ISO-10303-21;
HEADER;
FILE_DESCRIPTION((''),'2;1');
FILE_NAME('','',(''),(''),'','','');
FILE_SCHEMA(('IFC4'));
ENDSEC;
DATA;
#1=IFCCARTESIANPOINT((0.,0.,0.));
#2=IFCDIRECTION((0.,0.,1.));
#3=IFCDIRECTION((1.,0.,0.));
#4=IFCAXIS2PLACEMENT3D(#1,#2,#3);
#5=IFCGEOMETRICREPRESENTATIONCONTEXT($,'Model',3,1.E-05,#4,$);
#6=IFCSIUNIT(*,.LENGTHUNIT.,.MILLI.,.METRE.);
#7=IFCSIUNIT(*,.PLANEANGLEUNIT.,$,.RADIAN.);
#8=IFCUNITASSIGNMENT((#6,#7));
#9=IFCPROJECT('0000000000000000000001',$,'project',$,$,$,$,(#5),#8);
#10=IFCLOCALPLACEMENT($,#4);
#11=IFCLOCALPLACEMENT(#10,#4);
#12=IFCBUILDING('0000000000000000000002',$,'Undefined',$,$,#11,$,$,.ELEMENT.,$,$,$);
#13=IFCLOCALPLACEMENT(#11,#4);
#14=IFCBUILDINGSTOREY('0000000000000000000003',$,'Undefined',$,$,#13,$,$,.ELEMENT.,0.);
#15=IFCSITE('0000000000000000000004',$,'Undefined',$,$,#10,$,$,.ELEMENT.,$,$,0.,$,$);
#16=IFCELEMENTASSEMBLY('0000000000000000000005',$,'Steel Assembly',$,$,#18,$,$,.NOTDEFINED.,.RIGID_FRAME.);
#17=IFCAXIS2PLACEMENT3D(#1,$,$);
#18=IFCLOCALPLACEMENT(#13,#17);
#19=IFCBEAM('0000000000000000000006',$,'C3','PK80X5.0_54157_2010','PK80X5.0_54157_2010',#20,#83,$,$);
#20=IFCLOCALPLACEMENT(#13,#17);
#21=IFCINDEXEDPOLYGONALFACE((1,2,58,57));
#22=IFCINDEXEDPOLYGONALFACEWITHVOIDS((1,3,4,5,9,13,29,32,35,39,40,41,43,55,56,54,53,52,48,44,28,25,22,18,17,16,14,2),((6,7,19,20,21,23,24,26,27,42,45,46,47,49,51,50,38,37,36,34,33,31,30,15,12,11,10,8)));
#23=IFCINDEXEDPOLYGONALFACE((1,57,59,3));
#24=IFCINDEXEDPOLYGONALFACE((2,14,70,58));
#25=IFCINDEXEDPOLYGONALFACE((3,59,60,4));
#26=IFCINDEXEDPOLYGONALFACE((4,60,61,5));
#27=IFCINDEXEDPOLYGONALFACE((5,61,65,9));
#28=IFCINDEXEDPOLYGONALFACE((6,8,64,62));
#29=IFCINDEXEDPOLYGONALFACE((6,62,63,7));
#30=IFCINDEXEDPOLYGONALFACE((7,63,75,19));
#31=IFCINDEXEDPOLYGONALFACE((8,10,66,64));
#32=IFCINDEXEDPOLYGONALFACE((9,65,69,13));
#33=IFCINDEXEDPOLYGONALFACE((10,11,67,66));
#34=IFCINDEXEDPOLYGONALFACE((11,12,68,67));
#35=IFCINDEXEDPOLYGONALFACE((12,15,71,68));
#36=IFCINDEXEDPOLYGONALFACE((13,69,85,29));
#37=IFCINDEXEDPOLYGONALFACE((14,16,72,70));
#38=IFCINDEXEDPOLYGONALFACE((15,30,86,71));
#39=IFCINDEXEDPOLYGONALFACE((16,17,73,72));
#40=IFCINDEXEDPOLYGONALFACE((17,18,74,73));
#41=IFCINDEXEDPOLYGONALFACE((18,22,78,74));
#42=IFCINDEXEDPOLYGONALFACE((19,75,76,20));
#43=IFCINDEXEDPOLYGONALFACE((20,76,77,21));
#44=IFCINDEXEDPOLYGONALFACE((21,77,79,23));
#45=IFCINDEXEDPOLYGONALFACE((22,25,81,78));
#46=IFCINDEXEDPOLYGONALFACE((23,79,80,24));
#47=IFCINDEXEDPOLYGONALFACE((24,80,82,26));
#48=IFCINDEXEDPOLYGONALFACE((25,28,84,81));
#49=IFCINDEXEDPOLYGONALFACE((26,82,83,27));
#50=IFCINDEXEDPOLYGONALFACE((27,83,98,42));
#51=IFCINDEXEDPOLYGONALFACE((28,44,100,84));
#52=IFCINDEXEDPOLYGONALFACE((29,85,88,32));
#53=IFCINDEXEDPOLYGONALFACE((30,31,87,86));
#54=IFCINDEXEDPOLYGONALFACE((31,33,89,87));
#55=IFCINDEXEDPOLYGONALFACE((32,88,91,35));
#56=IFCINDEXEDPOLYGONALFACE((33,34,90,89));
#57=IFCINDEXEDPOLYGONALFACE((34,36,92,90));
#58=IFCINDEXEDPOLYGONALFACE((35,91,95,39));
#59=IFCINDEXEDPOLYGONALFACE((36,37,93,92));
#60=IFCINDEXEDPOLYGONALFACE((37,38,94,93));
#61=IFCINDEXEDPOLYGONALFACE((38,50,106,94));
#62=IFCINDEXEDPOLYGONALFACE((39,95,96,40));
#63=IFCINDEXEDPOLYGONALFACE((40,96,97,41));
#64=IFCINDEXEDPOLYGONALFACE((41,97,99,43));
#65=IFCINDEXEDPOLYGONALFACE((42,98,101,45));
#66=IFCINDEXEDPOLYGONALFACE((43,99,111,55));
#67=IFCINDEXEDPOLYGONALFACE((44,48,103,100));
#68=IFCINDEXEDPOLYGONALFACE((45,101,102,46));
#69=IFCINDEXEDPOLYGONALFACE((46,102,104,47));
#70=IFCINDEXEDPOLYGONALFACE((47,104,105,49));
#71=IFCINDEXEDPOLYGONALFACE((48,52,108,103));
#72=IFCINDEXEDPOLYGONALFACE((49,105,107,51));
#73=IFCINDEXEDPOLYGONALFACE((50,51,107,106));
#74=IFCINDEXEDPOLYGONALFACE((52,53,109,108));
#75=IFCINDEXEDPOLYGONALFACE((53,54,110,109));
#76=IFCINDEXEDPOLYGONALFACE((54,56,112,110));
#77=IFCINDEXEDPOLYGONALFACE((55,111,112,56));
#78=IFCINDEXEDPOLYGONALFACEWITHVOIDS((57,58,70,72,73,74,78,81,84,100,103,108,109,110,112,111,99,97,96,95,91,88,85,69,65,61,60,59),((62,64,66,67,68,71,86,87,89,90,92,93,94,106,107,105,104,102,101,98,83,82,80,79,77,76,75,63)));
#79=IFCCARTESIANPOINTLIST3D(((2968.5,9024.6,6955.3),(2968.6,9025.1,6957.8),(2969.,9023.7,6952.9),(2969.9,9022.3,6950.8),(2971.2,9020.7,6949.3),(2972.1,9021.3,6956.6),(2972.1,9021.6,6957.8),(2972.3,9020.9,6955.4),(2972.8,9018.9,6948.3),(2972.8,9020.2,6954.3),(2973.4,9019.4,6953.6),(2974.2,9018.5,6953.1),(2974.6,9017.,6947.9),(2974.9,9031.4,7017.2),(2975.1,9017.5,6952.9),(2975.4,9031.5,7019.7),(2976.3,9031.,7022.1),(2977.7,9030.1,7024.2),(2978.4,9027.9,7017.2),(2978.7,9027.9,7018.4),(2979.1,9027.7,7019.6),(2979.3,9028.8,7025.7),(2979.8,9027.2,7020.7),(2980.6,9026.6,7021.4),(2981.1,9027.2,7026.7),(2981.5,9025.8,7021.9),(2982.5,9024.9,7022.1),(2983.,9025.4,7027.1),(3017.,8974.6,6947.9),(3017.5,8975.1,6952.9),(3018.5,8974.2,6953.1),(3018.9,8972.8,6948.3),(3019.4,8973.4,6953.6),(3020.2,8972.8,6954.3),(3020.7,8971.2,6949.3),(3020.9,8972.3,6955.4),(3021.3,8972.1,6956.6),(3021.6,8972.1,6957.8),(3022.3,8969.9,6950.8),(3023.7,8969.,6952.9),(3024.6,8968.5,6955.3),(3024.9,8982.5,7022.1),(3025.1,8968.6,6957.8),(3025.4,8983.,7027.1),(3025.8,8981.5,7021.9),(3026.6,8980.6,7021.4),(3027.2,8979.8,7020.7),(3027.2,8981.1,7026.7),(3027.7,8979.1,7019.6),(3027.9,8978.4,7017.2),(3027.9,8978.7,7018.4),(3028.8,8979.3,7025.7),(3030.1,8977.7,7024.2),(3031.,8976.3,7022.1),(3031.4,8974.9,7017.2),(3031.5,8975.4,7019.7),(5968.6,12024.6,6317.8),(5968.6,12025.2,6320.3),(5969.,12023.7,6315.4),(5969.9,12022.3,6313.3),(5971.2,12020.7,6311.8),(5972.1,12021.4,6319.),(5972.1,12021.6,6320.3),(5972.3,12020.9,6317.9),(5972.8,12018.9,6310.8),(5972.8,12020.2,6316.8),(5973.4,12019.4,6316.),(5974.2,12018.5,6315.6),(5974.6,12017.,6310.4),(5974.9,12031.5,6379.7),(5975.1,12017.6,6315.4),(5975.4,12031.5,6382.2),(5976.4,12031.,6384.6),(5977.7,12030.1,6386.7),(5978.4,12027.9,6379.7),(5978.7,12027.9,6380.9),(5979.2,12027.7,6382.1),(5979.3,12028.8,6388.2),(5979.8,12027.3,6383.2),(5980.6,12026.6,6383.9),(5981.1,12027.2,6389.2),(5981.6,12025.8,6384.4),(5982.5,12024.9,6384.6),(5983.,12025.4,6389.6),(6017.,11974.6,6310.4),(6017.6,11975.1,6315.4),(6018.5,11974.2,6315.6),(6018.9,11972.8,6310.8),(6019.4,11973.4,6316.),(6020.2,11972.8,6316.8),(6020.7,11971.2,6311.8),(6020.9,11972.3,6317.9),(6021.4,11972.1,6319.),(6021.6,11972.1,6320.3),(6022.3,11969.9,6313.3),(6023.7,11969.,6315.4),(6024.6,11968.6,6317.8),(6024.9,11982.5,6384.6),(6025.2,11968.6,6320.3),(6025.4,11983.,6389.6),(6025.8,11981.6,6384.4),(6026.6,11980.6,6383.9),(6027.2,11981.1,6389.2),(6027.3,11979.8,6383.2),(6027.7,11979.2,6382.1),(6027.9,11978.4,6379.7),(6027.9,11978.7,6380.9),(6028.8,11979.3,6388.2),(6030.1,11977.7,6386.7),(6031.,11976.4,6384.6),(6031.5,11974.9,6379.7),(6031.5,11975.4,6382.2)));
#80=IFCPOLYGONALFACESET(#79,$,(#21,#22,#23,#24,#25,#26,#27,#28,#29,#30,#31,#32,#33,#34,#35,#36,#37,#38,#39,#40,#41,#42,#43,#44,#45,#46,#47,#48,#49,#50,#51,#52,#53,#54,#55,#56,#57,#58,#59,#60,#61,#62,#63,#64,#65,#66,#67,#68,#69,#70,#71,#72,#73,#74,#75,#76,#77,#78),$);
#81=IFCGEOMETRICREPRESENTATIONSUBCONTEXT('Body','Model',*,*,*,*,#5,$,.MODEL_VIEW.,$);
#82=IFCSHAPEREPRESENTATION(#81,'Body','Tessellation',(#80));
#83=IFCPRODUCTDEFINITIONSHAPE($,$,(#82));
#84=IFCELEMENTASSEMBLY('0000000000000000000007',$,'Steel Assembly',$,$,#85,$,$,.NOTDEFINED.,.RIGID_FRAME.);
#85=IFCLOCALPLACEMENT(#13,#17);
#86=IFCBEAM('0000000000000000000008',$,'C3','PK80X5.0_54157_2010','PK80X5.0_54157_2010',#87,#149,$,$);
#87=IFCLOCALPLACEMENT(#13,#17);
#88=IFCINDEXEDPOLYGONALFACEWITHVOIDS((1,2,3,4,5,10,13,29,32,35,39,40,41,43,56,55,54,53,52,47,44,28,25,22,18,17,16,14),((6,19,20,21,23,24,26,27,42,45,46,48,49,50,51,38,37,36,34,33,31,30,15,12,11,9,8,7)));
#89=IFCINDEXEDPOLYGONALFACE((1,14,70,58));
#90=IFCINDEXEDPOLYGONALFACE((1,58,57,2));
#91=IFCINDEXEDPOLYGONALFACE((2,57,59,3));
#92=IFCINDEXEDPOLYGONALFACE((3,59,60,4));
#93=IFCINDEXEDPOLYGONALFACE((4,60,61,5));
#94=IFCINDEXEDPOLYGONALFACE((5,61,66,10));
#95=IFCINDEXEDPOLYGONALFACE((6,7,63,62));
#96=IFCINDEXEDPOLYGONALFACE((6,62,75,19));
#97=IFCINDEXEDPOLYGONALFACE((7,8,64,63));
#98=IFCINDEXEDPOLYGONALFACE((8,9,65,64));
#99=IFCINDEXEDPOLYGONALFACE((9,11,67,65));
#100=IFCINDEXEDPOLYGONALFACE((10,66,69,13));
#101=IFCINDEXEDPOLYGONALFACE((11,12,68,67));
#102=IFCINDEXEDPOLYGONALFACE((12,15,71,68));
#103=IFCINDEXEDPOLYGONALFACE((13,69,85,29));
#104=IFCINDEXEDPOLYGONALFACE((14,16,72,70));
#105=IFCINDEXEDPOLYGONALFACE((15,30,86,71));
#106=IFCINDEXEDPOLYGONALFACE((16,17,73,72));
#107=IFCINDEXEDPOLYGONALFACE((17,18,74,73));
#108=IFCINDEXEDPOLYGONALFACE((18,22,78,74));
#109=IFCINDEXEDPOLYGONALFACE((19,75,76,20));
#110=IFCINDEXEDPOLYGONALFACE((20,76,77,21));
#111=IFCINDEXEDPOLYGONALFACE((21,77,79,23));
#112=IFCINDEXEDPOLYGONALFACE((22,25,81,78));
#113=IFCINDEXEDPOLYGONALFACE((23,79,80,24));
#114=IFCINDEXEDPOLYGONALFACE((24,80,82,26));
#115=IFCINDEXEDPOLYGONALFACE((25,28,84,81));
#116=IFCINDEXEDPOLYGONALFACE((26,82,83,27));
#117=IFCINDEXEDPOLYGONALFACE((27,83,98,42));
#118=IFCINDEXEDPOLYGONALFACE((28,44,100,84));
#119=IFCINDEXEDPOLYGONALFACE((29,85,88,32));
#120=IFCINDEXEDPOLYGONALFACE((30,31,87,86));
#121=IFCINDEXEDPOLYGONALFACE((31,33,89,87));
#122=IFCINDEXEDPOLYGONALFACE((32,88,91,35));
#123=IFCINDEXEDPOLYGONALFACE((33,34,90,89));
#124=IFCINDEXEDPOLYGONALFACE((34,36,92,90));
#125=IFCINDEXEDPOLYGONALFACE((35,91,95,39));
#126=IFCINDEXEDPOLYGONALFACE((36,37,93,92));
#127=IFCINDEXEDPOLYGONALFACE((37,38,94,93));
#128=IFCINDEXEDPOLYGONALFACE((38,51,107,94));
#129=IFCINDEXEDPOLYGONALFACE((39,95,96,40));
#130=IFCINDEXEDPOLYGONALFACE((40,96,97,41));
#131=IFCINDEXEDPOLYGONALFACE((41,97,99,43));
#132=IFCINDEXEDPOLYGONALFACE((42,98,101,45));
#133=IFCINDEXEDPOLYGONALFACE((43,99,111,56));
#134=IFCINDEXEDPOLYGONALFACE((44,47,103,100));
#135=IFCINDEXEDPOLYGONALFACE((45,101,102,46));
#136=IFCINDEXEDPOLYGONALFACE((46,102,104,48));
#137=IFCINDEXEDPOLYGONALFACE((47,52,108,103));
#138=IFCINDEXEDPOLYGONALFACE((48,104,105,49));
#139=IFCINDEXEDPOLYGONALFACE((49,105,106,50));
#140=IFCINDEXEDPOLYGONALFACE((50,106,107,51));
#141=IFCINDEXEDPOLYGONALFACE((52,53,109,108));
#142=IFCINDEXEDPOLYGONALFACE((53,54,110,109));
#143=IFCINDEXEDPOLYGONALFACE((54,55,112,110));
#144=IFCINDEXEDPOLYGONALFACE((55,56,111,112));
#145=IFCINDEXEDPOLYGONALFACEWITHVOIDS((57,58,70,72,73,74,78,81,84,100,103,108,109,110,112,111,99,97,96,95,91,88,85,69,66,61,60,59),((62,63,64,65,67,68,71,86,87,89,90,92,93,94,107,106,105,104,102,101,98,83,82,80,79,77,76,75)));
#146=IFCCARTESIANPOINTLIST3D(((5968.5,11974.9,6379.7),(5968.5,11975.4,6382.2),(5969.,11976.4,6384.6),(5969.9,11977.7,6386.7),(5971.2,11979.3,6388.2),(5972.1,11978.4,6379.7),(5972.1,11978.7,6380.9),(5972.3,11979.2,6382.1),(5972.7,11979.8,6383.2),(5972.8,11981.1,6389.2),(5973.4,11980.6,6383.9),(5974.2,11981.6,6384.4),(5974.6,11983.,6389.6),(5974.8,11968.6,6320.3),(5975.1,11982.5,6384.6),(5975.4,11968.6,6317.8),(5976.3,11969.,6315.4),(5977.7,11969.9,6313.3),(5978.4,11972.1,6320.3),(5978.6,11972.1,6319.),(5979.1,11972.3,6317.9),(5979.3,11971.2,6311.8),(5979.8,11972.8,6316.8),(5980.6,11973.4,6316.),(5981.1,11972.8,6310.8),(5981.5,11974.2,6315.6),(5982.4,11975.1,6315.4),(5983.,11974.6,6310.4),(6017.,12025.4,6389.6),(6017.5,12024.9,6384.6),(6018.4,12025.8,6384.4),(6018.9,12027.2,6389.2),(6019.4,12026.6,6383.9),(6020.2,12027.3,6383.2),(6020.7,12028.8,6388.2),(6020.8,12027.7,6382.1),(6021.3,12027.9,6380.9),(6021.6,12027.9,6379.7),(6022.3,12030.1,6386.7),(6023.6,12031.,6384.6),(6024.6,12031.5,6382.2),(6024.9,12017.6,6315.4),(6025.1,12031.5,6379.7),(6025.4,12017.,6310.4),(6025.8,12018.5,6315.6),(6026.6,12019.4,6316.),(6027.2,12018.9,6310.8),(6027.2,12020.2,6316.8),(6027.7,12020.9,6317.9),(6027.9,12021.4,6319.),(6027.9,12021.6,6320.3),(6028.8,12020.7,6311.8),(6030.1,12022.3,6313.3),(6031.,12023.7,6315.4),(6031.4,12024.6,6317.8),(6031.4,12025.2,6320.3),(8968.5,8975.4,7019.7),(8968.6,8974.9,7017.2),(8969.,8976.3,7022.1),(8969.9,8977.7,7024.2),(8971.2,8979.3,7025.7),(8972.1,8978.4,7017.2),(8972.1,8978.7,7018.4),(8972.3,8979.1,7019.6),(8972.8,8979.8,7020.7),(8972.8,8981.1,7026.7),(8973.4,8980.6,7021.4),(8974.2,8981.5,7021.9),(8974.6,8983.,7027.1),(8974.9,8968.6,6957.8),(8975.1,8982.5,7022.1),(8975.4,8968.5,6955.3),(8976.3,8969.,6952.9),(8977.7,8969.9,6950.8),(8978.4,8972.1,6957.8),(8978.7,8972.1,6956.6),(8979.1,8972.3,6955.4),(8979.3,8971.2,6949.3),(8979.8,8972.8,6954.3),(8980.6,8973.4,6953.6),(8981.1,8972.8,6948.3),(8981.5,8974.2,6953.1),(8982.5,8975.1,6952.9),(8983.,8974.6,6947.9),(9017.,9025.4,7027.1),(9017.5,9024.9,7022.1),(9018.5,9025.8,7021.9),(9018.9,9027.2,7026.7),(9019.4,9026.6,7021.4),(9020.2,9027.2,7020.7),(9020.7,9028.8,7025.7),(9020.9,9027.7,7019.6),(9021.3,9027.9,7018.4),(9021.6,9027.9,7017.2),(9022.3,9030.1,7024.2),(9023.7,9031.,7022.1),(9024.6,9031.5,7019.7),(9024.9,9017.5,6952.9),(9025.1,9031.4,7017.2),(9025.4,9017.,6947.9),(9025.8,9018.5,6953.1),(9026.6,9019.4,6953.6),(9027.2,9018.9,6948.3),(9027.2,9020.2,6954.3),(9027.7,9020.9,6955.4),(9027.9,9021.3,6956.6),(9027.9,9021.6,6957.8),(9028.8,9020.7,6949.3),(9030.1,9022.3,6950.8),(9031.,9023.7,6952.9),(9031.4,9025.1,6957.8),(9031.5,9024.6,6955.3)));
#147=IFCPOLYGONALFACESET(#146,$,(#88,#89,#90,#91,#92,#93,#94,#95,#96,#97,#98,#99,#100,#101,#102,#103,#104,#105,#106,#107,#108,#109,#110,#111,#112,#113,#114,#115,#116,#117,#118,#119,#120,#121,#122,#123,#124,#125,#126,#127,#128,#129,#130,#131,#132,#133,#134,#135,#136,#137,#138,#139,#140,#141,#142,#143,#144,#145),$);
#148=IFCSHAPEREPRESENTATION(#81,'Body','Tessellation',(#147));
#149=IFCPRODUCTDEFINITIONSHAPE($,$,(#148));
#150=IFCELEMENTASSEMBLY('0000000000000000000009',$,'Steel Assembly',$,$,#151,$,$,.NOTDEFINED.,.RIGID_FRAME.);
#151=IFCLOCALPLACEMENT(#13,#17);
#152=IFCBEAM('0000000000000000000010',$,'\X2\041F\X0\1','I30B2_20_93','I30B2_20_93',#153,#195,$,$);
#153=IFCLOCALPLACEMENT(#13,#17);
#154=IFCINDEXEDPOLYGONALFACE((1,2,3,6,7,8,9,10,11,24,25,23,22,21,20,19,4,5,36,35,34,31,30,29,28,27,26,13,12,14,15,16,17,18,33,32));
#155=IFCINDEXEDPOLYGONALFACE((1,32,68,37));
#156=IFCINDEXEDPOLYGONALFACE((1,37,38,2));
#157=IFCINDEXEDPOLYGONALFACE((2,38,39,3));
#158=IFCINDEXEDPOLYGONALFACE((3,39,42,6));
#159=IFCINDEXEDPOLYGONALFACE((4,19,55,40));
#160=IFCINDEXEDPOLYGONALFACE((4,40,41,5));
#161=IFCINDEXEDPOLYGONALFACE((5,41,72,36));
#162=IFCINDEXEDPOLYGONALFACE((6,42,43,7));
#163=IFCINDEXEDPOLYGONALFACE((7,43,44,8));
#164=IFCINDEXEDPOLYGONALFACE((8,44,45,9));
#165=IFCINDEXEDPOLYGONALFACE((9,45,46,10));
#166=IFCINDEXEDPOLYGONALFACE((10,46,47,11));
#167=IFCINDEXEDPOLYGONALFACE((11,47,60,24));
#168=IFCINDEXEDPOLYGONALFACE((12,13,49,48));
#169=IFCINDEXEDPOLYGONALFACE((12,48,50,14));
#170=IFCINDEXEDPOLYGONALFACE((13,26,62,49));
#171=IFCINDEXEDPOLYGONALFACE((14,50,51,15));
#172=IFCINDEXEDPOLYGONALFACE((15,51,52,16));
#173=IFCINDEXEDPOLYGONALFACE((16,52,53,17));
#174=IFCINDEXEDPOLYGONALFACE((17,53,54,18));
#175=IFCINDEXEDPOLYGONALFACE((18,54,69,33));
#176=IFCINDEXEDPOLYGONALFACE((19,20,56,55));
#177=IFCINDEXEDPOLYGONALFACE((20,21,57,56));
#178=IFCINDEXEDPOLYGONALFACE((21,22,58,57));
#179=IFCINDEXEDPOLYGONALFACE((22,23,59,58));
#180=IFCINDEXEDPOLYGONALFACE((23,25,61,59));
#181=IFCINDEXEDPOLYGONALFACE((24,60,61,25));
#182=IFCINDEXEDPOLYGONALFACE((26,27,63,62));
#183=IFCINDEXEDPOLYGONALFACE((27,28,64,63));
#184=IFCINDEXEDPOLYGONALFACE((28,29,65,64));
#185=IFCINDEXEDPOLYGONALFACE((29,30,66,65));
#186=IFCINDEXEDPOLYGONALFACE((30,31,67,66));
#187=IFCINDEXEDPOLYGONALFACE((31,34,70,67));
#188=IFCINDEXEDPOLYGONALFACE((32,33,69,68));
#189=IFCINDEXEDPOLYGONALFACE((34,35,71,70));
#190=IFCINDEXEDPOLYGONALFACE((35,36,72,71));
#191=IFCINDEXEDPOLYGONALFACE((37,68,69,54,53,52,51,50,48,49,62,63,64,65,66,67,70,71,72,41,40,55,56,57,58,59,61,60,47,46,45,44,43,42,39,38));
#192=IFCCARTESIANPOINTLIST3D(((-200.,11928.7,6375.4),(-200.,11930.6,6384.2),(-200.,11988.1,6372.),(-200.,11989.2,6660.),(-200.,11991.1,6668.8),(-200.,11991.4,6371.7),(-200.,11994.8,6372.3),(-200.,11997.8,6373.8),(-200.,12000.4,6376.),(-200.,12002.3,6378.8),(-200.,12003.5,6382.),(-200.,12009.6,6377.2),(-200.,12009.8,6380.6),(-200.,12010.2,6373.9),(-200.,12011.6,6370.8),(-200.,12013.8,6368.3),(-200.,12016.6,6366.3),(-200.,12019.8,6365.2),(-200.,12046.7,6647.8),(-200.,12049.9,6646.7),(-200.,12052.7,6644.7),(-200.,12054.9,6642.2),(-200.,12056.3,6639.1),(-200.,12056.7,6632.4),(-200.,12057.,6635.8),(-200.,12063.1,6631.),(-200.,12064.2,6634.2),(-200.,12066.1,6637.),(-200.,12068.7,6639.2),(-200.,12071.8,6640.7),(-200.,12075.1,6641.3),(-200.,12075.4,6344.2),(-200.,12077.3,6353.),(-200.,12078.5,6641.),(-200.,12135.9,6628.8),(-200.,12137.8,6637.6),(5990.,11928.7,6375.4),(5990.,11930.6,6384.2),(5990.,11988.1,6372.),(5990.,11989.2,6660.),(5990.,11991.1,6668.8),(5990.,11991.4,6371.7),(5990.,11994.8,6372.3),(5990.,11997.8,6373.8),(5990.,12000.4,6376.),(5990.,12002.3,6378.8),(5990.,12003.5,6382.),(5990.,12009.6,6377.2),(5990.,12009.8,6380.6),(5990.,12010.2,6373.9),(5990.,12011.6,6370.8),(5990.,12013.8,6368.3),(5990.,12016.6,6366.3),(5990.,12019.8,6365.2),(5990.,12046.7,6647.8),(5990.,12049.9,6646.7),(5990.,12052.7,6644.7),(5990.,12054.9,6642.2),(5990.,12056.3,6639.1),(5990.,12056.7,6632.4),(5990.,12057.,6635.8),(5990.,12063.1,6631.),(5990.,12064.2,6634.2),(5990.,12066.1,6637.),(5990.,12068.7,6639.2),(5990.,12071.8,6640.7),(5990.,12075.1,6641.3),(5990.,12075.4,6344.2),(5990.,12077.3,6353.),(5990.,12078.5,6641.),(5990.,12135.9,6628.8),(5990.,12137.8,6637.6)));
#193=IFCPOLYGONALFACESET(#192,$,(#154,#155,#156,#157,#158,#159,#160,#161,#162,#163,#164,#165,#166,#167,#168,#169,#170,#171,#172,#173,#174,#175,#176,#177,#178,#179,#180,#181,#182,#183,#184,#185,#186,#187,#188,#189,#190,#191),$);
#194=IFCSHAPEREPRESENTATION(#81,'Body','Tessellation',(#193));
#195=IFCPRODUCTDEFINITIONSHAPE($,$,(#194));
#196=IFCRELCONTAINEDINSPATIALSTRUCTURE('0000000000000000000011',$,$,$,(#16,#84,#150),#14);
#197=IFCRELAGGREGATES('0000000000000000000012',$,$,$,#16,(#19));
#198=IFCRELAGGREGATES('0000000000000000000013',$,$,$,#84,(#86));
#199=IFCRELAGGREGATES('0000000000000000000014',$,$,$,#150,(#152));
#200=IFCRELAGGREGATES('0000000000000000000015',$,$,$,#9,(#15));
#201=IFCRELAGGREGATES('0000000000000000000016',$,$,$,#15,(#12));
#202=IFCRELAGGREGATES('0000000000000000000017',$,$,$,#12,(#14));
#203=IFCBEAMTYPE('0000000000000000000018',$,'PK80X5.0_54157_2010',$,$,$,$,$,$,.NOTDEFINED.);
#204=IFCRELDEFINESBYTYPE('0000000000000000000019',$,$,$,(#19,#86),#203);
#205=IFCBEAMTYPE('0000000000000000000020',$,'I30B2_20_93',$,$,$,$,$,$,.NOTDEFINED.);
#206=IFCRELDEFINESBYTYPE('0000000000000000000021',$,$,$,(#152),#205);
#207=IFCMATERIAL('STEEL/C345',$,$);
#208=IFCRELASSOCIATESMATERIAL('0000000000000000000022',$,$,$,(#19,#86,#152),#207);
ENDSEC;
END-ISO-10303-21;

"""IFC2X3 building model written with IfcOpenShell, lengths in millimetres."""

from ifc_helpers import new_model, si_unit, frame, origin_with_axes, origin_2d_with_axis, place, context, subcontext, project, spatial, hollow_rectangle, i_section, extrude, material, type_object, element, aggregate, save


model = new_model("IFC2X3")

# Units and contexts
model_context = context("Model", 3, precision=1e-05, world=origin_with_axes())
body_context = subcontext(model_context, "Body", "Model", "MODEL_VIEW")
ifc_project = project(units=[si_unit("LENGTHUNIT", "METRE", prefix="MILLI"), si_unit("PLANEANGLEUNIT", "RADIAN")], contexts=[model_context])

# Site, building, storey
site_placement = place(None, origin_with_axes())
site = spatial("IfcSite", under=ifc_project, at=site_placement, Name="Undefined", CompositionType="ELEMENT", RefElevation=0.0)
building_placement = place(site_placement, origin_with_axes())
building = spatial("IfcBuilding", under=site, at=building_placement, Name="Undefined", CompositionType="ELEMENT")
storey_placement = place(building_placement, origin_with_axes())
storey = spatial("IfcBuildingStorey", under=building, at=storey_placement, Name="Undefined", CompositionType="ELEMENT", Elevation=0.0)

# Shared definitions
ifc_material_1 = material(Name="STEEL/C345")

# Element assemblies, beams
assembly_1_placement = place(storey_placement, origin_with_axes())
assembly_1 = element("IfcElementAssembly", 1, at=assembly_1_placement, inside=storey, Name="Steel Assembly", AssemblyPlace="NOTDEFINED", PredefinedType="RIGID_FRAME")
beam_type_1 = type_object("IfcBeamType", Name="PK80X5.0_54157_2010", PredefinedType="NOTDEFINED")
beam_1_placement = place(assembly_1_placement, frame((6000.0, 12000.0, 6350.0), z_axis=(0.10507, 0.10507, 0.988899), x_axis=(-0.699257, -0.699257, 0.148592)))
beam_1 = element("IfcBeam", 2, at=beam_1_placement, type_object=beam_type_1, material=ifc_material_1, Name="C3", Description="PK80X5.0_54157_2010", ObjectType="PK80X5.0_54157_2010", context=body_context, shape_type="SweptSolid", body=[
    extrude(hollow_rectangle(XDim=80.0, YDim=80.0, WallThickness=5.0, InnerFilletRadius=5.0, OuterFilletRadius=10.0, at=origin_2d_with_axis()), frame((4290.3, 0.0, 0.0), z_axis=(-1.0, 0.0, 0.0), x_axis=(0.0, -1.0, 0.0)), (0.0, 0.0, 1.0), 4290.3),
])
aggregate(assembly_1, [beam_1])
assembly_2_placement = place(storey_placement, origin_with_axes())
assembly_2 = element("IfcElementAssembly", 3, at=assembly_2_placement, inside=storey, Name="Steel Assembly", AssemblyPlace="NOTDEFINED", PredefinedType="RIGID_FRAME")
beam_2_placement = place(assembly_2_placement, frame((6000.0, 12000.0, 6350.0), z_axis=(-0.10507, 0.10507, 0.988899), x_axis=(0.699257, -0.699257, 0.148592)))
beam_2 = element("IfcBeam", 4, at=beam_2_placement, type_object=beam_type_1, material=ifc_material_1, Name="C3", Description="PK80X5.0_54157_2010", ObjectType="PK80X5.0_54157_2010", context=body_context, shape_type="SweptSolid", body=[
    extrude(hollow_rectangle(XDim=80.0, YDim=80.0, WallThickness=5.0, InnerFilletRadius=5.0, OuterFilletRadius=10.0, at=origin_2d_with_axis()), frame((4290.3, 0.0, 0.0), z_axis=(-1.0, 0.0, 0.0), x_axis=(0.0, -1.0, 0.0)), (0.0, 0.0, 1.0), 4290.3),
])
aggregate(assembly_2, [beam_2])
assembly_3_placement = place(storey_placement, origin_with_axes())
assembly_3 = element("IfcElementAssembly", 5, at=assembly_3_placement, inside=storey, Name="Steel Assembly", AssemblyPlace="NOTDEFINED", PredefinedType="RIGID_FRAME")
beam_type_2 = type_object("IfcBeamType", Name="I30B2_20_93", PredefinedType="NOTDEFINED")
beam_3_placement = place(assembly_3_placement, frame((5990.0, 12033.3, 6506.5), z_axis=(0.0, -0.207912, -0.978148), x_axis=(-1.0, 0.0, 0.0)))
beam_3 = element("IfcBeam", 6, at=beam_3_placement, type_object=beam_type_2, material=ifc_material_1, Name="П1", Description="I30B2_20_93", ObjectType="I30B2_20_93", context=body_context, shape_type="SweptSolid", body=[
    extrude(i_section(OverallWidth=150.0, OverallDepth=300.0, WebThickness=6.5, FlangeThickness=9.0, FilletRadius=13.0, at=origin_2d_with_axis()), frame((6190.0, 0.0, 0.0), z_axis=(-1.0, 0.0, 0.0), x_axis=(0.0, -1.0, 0.0)), (0.0, 0.0, 1.0), 6190.0),
])
aggregate(assembly_3, [beam_3])

save(model, "model.ifc")
